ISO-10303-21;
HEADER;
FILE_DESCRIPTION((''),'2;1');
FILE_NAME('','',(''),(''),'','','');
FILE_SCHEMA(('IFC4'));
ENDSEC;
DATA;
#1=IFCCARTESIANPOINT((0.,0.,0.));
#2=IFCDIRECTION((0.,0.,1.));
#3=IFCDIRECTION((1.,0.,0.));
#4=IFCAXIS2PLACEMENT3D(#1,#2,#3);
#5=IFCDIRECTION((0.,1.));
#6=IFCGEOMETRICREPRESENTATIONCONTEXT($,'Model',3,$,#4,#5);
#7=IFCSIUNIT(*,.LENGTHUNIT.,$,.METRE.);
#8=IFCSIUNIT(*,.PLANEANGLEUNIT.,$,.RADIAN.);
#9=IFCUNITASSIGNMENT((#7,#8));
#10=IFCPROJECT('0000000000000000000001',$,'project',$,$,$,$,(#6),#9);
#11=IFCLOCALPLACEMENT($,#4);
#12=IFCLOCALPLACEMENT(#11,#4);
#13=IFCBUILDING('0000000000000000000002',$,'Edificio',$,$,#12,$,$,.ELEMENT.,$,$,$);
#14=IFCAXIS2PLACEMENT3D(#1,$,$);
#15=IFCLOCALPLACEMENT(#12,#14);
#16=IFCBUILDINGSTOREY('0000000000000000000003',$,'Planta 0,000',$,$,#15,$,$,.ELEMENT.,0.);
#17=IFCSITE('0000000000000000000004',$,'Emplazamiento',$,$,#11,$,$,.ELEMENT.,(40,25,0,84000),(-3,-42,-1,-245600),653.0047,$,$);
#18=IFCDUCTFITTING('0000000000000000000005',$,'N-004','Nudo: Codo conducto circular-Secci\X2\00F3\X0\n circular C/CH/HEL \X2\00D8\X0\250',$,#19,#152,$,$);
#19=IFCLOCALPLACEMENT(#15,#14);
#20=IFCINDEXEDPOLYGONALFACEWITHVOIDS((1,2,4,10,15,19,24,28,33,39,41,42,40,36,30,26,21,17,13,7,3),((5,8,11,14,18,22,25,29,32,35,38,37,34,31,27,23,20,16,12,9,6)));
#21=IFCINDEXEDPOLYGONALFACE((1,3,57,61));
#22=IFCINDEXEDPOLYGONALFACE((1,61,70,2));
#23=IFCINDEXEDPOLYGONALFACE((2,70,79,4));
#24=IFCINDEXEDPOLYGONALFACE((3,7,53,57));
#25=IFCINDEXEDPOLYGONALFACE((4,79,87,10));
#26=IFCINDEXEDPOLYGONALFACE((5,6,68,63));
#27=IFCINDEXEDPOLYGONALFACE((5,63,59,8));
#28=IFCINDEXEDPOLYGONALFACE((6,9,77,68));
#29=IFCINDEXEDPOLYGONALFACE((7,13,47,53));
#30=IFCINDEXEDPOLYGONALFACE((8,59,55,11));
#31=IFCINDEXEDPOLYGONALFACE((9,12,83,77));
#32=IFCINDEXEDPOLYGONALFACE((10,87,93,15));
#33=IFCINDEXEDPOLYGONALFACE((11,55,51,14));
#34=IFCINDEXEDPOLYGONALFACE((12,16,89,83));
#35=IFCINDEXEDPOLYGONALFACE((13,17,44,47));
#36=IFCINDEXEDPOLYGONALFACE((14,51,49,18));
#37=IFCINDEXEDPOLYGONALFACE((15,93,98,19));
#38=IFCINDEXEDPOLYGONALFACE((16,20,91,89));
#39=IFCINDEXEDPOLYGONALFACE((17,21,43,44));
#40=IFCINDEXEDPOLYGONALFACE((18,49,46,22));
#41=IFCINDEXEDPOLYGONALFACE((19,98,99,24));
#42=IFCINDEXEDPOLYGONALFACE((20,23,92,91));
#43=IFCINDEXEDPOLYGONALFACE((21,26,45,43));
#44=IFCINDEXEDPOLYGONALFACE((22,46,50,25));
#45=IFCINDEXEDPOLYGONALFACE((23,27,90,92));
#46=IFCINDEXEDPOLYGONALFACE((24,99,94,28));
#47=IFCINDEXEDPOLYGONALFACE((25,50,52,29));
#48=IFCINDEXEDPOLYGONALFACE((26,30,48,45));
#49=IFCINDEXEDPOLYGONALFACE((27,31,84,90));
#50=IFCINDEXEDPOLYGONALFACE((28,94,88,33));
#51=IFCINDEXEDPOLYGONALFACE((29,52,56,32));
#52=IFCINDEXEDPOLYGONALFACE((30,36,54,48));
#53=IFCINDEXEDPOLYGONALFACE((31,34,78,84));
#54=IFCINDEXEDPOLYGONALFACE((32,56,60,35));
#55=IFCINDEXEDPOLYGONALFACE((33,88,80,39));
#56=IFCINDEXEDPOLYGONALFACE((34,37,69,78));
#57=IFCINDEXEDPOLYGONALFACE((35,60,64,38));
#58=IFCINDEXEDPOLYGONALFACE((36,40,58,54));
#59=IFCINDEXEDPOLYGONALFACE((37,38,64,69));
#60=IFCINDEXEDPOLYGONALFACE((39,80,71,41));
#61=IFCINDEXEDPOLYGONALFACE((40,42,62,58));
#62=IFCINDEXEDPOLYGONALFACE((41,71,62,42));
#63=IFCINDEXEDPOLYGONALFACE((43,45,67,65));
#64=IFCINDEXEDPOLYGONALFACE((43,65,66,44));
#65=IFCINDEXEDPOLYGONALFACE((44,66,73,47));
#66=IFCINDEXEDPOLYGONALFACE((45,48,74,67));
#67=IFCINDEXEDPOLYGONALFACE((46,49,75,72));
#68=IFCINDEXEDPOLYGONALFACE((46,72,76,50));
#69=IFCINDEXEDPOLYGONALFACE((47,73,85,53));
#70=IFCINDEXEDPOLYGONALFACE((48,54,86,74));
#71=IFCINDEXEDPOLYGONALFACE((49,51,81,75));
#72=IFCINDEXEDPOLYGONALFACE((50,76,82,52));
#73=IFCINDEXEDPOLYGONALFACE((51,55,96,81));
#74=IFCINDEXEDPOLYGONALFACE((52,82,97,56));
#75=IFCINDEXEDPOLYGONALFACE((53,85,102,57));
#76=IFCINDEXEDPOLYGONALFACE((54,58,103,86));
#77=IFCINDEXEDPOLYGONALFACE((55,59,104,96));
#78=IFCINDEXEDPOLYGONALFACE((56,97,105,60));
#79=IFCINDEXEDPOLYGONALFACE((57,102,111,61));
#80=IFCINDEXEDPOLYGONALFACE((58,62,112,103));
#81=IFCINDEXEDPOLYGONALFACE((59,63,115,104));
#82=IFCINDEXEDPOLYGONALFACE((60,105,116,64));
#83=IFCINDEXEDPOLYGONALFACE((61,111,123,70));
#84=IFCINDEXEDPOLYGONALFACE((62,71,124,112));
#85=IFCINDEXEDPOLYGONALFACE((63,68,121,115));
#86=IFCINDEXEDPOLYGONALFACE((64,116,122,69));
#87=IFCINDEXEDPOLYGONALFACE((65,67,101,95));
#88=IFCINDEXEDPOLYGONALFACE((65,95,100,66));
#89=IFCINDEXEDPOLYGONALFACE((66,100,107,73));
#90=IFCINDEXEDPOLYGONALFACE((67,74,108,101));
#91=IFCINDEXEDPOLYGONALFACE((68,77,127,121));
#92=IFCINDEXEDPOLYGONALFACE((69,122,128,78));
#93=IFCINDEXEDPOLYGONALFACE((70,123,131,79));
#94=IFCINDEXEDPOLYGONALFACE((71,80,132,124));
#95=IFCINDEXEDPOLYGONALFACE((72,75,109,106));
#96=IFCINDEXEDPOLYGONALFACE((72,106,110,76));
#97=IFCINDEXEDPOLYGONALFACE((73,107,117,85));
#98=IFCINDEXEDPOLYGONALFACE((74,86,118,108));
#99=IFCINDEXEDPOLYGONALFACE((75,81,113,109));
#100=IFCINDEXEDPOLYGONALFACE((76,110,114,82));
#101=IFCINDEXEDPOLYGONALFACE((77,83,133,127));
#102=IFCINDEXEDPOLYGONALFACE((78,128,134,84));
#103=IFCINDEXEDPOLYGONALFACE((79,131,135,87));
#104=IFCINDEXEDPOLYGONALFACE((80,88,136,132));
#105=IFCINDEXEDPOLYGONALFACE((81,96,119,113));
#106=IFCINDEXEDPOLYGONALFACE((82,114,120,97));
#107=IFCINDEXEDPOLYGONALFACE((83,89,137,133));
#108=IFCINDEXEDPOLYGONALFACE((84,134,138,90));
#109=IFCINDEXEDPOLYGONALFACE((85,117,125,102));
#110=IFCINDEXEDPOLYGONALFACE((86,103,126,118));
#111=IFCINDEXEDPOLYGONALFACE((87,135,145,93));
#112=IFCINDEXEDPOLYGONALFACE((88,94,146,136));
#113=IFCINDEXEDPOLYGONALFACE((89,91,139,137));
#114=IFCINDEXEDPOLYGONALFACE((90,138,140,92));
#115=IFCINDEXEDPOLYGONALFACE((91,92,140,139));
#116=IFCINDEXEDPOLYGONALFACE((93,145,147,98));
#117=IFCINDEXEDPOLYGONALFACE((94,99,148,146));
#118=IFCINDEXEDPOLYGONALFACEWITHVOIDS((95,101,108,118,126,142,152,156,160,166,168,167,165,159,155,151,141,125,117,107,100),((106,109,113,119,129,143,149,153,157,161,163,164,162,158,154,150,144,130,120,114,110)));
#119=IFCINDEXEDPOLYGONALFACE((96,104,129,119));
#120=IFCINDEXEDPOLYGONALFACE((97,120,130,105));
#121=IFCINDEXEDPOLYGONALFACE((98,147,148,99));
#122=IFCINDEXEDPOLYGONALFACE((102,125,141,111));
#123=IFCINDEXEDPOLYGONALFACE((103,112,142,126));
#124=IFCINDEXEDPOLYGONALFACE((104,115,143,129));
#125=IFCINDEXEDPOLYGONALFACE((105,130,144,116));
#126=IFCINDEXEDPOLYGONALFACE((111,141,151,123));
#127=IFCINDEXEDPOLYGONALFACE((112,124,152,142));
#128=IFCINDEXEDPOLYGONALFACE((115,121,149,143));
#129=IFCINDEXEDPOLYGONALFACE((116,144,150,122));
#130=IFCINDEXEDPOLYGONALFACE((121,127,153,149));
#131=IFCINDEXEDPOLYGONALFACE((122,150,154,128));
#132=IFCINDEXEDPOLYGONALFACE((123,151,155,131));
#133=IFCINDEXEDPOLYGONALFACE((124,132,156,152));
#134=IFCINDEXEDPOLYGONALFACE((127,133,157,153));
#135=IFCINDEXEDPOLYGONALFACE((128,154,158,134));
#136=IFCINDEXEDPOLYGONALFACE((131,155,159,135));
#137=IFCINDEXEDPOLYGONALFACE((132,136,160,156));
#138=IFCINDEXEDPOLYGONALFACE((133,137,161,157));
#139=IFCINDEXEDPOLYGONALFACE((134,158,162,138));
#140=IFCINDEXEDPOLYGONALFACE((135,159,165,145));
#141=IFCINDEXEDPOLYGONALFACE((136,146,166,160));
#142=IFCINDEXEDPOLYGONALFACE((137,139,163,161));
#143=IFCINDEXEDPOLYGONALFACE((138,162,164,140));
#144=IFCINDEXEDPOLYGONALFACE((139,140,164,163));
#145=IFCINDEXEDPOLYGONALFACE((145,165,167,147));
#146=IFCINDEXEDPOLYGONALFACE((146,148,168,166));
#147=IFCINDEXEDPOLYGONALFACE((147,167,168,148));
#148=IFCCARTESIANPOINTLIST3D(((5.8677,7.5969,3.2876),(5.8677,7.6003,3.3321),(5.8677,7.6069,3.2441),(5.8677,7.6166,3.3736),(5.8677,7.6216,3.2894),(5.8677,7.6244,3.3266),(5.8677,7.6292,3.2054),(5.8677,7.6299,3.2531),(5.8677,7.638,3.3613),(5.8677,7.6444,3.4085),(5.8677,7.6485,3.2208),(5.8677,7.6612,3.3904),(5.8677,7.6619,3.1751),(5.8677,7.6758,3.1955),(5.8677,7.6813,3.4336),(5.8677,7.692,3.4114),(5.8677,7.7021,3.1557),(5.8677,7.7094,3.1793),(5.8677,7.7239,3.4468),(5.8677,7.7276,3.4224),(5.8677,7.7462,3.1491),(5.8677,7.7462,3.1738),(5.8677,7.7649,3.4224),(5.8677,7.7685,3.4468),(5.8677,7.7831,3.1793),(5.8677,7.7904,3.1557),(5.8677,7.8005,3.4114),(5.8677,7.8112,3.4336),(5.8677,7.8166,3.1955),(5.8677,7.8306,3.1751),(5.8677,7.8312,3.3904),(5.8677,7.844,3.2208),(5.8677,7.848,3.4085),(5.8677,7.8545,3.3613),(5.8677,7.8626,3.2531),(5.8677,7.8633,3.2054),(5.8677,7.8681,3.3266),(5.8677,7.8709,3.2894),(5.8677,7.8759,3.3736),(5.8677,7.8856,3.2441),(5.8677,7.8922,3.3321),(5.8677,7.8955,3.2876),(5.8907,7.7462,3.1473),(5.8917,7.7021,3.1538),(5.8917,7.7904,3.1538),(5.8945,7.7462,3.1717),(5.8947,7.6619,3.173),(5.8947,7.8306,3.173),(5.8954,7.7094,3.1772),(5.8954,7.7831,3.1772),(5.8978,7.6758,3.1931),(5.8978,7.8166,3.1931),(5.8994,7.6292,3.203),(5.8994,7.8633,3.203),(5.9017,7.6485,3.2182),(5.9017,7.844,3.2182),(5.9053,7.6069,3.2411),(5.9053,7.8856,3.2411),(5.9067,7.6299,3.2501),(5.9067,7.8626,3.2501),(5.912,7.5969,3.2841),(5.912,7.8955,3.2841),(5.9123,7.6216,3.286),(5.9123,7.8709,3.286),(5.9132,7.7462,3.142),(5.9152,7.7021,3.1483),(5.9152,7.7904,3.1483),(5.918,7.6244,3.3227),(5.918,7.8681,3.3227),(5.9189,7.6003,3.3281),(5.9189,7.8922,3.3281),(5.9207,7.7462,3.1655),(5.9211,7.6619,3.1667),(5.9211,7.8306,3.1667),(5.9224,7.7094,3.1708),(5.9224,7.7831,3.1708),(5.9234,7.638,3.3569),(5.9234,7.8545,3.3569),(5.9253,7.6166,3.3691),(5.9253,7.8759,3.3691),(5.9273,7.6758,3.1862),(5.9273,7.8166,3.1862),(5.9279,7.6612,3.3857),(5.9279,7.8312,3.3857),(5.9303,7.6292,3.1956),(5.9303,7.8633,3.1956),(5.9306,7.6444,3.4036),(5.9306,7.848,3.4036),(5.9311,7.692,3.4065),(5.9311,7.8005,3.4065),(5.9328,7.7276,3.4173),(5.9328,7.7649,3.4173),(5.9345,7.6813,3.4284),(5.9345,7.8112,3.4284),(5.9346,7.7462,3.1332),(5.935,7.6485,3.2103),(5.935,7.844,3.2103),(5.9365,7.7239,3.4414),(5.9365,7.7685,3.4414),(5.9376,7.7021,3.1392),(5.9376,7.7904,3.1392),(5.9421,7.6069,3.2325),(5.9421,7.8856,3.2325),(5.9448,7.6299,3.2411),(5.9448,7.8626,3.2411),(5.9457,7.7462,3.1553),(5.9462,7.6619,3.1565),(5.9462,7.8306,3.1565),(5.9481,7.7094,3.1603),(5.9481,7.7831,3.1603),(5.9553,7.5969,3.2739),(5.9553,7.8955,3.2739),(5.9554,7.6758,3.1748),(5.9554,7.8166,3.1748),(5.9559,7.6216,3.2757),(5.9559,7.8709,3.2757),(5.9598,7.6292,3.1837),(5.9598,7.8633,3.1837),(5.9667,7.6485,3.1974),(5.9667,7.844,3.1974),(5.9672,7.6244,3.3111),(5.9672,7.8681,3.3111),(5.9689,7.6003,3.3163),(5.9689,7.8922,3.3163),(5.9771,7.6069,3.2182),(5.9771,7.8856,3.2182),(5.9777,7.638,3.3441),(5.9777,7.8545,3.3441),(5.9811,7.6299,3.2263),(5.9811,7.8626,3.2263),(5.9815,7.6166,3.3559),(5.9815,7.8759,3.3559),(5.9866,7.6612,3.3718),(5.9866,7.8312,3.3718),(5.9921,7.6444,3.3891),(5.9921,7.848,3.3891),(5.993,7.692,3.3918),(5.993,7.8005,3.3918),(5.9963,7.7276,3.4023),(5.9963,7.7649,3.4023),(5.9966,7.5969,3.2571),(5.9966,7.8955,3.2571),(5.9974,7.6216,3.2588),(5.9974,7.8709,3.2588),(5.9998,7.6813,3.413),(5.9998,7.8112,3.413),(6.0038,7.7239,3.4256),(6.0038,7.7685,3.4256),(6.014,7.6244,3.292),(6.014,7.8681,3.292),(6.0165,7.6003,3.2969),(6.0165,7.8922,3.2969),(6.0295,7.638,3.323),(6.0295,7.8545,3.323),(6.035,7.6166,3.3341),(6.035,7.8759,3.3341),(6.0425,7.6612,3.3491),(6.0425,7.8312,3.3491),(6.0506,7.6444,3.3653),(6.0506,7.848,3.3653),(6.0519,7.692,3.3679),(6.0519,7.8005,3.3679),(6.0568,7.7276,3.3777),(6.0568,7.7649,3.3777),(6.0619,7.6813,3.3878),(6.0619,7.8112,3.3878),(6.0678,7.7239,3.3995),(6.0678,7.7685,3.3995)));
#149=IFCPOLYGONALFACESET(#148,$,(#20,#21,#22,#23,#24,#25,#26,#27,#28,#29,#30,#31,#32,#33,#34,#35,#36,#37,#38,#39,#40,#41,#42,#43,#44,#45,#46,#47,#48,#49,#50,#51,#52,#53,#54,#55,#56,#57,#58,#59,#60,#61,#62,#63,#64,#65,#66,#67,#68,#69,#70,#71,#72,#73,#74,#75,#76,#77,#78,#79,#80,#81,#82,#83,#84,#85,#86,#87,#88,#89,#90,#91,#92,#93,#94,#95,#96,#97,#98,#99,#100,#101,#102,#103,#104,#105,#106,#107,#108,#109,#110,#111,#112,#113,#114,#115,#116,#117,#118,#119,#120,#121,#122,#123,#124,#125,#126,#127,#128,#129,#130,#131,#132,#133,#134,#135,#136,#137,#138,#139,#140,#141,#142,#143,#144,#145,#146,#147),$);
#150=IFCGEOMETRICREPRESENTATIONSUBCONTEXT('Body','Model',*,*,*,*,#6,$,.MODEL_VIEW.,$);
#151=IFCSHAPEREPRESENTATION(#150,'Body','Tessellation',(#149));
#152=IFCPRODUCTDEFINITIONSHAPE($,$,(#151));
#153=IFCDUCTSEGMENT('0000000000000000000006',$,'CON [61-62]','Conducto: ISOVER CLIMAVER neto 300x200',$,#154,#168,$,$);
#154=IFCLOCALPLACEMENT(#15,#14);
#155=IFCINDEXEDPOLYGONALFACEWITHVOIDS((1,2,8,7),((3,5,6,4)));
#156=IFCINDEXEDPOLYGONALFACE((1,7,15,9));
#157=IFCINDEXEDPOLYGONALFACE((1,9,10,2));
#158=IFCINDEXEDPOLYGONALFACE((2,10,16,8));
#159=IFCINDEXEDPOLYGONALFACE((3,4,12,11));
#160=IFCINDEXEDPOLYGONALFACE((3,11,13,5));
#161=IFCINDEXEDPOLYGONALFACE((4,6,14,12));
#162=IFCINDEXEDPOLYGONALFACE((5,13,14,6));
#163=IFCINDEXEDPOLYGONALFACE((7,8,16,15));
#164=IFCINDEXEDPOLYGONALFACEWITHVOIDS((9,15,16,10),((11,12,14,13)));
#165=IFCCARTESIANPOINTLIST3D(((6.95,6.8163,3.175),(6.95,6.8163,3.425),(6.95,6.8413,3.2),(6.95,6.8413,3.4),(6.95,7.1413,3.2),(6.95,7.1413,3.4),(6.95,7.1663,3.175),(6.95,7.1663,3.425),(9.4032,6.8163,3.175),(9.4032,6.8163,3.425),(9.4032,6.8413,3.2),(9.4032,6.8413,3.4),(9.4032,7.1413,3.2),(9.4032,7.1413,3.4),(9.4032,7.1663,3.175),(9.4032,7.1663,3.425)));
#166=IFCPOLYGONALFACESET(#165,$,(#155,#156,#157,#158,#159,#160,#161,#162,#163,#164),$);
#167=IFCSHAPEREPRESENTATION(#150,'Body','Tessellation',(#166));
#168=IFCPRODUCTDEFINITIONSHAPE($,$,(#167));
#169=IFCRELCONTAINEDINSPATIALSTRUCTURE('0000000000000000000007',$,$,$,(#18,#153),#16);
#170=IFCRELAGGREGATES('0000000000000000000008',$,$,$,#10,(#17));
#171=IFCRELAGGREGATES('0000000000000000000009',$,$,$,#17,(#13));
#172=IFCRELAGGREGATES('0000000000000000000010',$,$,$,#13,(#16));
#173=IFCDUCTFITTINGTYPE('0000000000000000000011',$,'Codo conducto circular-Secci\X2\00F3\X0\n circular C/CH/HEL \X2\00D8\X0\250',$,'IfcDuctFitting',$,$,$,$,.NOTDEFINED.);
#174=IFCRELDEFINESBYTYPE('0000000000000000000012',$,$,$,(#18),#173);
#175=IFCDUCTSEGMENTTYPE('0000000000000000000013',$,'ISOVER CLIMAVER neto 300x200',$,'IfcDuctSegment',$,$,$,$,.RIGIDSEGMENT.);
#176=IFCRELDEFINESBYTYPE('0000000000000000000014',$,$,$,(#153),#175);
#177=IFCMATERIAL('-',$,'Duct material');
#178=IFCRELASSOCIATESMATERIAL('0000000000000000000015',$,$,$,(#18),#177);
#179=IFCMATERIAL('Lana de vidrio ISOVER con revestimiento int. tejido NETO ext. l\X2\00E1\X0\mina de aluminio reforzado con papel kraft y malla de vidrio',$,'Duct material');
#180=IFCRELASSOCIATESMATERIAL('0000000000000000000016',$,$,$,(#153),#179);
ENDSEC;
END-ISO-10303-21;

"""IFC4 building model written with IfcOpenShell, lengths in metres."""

from ifc_helpers import new_model, entity, si_unit, direction, frame, origin, origin_with_axes, origin_2d_with_axis, place, context, subcontext, project, spatial, hollow_rectangle, extrude, source, transform, mapped, material, type_object, element, save


model = new_model("IFC4")

# Units and contexts
model_context = context("Model", 3, world=origin_with_axes(), true_north=direction((0.0, 1.0)))
body_context = subcontext(model_context, "Body", "Model", "MODEL_VIEW")
ifc_project = project(units=[si_unit("LENGTHUNIT", "METRE"), si_unit("PLANEANGLEUNIT", "RADIAN")], contexts=[model_context])

# Site, building, storey
site_placement = place(None, origin_with_axes())
site = spatial("IfcSite", under=ifc_project, at=site_placement, Name="Emplazamiento", CompositionType="ELEMENT", RefLatitude=(40, 25, 0, 84000), RefLongitude=(-3, -42, -1, -245600), RefElevation=653.0047)
building_placement = place(site_placement, origin_with_axes())
building = spatial("IfcBuilding", under=site, at=building_placement, Name="Edificio", CompositionType="ELEMENT")
storey_placement = place(building_placement, origin())
storey = spatial("IfcBuildingStorey", under=building, at=storey_placement, Name="Planta 0,000", CompositionType="ELEMENT", Elevation=0.0)

# Shared definitions
ifc_material_1 = material(Name="Lana de vidrio ISOVER con revestimiento int. tejido NETO ext. lámina de aluminio reforzado con papel kraft y malla de vidrio", Category="Duct material")
ifc_material_2 = material(Name="-", Category="Duct material")

# Shared definitions
duct_fitting_type_1 = type_object("IfcDuctFittingType", Name="Codo conducto circular-Sección circular C/CH/HEL Ø250", ApplicableOccurrence="IfcDuctFitting", PredefinedType="NOTDEFINED")

# Duct fitting
shared_shape_1 = source(origin_with_axes(), body_context, "Body", "SweptSolid", [
    entity("IfcRevolvedAreaSolid", entity("IfcCircleHollowProfileDef", "AREA", None, entity("IfcAxis2Placement2D", entity("IfcCartesianPoint", [0.0, 0.0]), entity("IfcDirection", [1.0, 0.0])), 0.1497, 0.0247), entity("IfcAxis2Placement3D", entity("IfcCartesianPoint", [0.0316, 0.0632, 0.0]), entity("IfcDirection", [-0.447214, -0.894427, 0.0]), entity("IfcDirection", [0.894427, -0.447214, 0.0])), entity("IfcAxis1Placement", entity("IfcCartesianPoint", [0.2994, 0.0, 0.0]), entity("IfcDirection", [0.0, 1.0, 0.0])), 0.463648),
])
duct_fitting_1_placement = place(storey_placement, origin_with_axes())
element("IfcDuctFitting", 1, at=duct_fitting_1_placement, inside=storey, type_object=duct_fitting_type_1, material=ifc_material_2, Name="N-004", Description="Nudo: Codo conducto circular-Sección circular C/CH/HEL Ø250", context=body_context, shape_type="MappedRepresentation", body=[
    mapped(shared_shape_1, transform((5.9383, 7.7462, 3.2988), x_axis=(0.0, 0.0, -1.0), y_axis=(1.0, 0.0, 0.0), z_axis=(0.0, -1.0, 0.0), scale=1.0)),
])

# Duct segment
duct_segment_type_1 = type_object("IfcDuctSegmentType", Name="ISOVER CLIMAVER neto 300x200", ApplicableOccurrence="IfcDuctSegment", PredefinedType="RIGIDSEGMENT")
duct_segment_1_placement = place(storey_placement, origin_with_axes())
element("IfcDuctSegment", 2, at=duct_segment_1_placement, inside=storey, type_object=duct_segment_type_1, material=ifc_material_1, Name="CON [61-62]", Description="Conducto: ISOVER CLIMAVER neto 300x200", context=body_context, shape_type="SweptSolid", body=[
    extrude(hollow_rectangle(XDim=0.35, YDim=0.25, WallThickness=0.025, at=origin_2d_with_axis()), frame((9.4032, 6.9913, 3.3), z_axis=(-1.0, 0.0, 0.0), x_axis=(0.0, -1.0, 0.0)), (0.0, 0.0, 1.0), 2.4532),
])

save(model, "model.ifc")
